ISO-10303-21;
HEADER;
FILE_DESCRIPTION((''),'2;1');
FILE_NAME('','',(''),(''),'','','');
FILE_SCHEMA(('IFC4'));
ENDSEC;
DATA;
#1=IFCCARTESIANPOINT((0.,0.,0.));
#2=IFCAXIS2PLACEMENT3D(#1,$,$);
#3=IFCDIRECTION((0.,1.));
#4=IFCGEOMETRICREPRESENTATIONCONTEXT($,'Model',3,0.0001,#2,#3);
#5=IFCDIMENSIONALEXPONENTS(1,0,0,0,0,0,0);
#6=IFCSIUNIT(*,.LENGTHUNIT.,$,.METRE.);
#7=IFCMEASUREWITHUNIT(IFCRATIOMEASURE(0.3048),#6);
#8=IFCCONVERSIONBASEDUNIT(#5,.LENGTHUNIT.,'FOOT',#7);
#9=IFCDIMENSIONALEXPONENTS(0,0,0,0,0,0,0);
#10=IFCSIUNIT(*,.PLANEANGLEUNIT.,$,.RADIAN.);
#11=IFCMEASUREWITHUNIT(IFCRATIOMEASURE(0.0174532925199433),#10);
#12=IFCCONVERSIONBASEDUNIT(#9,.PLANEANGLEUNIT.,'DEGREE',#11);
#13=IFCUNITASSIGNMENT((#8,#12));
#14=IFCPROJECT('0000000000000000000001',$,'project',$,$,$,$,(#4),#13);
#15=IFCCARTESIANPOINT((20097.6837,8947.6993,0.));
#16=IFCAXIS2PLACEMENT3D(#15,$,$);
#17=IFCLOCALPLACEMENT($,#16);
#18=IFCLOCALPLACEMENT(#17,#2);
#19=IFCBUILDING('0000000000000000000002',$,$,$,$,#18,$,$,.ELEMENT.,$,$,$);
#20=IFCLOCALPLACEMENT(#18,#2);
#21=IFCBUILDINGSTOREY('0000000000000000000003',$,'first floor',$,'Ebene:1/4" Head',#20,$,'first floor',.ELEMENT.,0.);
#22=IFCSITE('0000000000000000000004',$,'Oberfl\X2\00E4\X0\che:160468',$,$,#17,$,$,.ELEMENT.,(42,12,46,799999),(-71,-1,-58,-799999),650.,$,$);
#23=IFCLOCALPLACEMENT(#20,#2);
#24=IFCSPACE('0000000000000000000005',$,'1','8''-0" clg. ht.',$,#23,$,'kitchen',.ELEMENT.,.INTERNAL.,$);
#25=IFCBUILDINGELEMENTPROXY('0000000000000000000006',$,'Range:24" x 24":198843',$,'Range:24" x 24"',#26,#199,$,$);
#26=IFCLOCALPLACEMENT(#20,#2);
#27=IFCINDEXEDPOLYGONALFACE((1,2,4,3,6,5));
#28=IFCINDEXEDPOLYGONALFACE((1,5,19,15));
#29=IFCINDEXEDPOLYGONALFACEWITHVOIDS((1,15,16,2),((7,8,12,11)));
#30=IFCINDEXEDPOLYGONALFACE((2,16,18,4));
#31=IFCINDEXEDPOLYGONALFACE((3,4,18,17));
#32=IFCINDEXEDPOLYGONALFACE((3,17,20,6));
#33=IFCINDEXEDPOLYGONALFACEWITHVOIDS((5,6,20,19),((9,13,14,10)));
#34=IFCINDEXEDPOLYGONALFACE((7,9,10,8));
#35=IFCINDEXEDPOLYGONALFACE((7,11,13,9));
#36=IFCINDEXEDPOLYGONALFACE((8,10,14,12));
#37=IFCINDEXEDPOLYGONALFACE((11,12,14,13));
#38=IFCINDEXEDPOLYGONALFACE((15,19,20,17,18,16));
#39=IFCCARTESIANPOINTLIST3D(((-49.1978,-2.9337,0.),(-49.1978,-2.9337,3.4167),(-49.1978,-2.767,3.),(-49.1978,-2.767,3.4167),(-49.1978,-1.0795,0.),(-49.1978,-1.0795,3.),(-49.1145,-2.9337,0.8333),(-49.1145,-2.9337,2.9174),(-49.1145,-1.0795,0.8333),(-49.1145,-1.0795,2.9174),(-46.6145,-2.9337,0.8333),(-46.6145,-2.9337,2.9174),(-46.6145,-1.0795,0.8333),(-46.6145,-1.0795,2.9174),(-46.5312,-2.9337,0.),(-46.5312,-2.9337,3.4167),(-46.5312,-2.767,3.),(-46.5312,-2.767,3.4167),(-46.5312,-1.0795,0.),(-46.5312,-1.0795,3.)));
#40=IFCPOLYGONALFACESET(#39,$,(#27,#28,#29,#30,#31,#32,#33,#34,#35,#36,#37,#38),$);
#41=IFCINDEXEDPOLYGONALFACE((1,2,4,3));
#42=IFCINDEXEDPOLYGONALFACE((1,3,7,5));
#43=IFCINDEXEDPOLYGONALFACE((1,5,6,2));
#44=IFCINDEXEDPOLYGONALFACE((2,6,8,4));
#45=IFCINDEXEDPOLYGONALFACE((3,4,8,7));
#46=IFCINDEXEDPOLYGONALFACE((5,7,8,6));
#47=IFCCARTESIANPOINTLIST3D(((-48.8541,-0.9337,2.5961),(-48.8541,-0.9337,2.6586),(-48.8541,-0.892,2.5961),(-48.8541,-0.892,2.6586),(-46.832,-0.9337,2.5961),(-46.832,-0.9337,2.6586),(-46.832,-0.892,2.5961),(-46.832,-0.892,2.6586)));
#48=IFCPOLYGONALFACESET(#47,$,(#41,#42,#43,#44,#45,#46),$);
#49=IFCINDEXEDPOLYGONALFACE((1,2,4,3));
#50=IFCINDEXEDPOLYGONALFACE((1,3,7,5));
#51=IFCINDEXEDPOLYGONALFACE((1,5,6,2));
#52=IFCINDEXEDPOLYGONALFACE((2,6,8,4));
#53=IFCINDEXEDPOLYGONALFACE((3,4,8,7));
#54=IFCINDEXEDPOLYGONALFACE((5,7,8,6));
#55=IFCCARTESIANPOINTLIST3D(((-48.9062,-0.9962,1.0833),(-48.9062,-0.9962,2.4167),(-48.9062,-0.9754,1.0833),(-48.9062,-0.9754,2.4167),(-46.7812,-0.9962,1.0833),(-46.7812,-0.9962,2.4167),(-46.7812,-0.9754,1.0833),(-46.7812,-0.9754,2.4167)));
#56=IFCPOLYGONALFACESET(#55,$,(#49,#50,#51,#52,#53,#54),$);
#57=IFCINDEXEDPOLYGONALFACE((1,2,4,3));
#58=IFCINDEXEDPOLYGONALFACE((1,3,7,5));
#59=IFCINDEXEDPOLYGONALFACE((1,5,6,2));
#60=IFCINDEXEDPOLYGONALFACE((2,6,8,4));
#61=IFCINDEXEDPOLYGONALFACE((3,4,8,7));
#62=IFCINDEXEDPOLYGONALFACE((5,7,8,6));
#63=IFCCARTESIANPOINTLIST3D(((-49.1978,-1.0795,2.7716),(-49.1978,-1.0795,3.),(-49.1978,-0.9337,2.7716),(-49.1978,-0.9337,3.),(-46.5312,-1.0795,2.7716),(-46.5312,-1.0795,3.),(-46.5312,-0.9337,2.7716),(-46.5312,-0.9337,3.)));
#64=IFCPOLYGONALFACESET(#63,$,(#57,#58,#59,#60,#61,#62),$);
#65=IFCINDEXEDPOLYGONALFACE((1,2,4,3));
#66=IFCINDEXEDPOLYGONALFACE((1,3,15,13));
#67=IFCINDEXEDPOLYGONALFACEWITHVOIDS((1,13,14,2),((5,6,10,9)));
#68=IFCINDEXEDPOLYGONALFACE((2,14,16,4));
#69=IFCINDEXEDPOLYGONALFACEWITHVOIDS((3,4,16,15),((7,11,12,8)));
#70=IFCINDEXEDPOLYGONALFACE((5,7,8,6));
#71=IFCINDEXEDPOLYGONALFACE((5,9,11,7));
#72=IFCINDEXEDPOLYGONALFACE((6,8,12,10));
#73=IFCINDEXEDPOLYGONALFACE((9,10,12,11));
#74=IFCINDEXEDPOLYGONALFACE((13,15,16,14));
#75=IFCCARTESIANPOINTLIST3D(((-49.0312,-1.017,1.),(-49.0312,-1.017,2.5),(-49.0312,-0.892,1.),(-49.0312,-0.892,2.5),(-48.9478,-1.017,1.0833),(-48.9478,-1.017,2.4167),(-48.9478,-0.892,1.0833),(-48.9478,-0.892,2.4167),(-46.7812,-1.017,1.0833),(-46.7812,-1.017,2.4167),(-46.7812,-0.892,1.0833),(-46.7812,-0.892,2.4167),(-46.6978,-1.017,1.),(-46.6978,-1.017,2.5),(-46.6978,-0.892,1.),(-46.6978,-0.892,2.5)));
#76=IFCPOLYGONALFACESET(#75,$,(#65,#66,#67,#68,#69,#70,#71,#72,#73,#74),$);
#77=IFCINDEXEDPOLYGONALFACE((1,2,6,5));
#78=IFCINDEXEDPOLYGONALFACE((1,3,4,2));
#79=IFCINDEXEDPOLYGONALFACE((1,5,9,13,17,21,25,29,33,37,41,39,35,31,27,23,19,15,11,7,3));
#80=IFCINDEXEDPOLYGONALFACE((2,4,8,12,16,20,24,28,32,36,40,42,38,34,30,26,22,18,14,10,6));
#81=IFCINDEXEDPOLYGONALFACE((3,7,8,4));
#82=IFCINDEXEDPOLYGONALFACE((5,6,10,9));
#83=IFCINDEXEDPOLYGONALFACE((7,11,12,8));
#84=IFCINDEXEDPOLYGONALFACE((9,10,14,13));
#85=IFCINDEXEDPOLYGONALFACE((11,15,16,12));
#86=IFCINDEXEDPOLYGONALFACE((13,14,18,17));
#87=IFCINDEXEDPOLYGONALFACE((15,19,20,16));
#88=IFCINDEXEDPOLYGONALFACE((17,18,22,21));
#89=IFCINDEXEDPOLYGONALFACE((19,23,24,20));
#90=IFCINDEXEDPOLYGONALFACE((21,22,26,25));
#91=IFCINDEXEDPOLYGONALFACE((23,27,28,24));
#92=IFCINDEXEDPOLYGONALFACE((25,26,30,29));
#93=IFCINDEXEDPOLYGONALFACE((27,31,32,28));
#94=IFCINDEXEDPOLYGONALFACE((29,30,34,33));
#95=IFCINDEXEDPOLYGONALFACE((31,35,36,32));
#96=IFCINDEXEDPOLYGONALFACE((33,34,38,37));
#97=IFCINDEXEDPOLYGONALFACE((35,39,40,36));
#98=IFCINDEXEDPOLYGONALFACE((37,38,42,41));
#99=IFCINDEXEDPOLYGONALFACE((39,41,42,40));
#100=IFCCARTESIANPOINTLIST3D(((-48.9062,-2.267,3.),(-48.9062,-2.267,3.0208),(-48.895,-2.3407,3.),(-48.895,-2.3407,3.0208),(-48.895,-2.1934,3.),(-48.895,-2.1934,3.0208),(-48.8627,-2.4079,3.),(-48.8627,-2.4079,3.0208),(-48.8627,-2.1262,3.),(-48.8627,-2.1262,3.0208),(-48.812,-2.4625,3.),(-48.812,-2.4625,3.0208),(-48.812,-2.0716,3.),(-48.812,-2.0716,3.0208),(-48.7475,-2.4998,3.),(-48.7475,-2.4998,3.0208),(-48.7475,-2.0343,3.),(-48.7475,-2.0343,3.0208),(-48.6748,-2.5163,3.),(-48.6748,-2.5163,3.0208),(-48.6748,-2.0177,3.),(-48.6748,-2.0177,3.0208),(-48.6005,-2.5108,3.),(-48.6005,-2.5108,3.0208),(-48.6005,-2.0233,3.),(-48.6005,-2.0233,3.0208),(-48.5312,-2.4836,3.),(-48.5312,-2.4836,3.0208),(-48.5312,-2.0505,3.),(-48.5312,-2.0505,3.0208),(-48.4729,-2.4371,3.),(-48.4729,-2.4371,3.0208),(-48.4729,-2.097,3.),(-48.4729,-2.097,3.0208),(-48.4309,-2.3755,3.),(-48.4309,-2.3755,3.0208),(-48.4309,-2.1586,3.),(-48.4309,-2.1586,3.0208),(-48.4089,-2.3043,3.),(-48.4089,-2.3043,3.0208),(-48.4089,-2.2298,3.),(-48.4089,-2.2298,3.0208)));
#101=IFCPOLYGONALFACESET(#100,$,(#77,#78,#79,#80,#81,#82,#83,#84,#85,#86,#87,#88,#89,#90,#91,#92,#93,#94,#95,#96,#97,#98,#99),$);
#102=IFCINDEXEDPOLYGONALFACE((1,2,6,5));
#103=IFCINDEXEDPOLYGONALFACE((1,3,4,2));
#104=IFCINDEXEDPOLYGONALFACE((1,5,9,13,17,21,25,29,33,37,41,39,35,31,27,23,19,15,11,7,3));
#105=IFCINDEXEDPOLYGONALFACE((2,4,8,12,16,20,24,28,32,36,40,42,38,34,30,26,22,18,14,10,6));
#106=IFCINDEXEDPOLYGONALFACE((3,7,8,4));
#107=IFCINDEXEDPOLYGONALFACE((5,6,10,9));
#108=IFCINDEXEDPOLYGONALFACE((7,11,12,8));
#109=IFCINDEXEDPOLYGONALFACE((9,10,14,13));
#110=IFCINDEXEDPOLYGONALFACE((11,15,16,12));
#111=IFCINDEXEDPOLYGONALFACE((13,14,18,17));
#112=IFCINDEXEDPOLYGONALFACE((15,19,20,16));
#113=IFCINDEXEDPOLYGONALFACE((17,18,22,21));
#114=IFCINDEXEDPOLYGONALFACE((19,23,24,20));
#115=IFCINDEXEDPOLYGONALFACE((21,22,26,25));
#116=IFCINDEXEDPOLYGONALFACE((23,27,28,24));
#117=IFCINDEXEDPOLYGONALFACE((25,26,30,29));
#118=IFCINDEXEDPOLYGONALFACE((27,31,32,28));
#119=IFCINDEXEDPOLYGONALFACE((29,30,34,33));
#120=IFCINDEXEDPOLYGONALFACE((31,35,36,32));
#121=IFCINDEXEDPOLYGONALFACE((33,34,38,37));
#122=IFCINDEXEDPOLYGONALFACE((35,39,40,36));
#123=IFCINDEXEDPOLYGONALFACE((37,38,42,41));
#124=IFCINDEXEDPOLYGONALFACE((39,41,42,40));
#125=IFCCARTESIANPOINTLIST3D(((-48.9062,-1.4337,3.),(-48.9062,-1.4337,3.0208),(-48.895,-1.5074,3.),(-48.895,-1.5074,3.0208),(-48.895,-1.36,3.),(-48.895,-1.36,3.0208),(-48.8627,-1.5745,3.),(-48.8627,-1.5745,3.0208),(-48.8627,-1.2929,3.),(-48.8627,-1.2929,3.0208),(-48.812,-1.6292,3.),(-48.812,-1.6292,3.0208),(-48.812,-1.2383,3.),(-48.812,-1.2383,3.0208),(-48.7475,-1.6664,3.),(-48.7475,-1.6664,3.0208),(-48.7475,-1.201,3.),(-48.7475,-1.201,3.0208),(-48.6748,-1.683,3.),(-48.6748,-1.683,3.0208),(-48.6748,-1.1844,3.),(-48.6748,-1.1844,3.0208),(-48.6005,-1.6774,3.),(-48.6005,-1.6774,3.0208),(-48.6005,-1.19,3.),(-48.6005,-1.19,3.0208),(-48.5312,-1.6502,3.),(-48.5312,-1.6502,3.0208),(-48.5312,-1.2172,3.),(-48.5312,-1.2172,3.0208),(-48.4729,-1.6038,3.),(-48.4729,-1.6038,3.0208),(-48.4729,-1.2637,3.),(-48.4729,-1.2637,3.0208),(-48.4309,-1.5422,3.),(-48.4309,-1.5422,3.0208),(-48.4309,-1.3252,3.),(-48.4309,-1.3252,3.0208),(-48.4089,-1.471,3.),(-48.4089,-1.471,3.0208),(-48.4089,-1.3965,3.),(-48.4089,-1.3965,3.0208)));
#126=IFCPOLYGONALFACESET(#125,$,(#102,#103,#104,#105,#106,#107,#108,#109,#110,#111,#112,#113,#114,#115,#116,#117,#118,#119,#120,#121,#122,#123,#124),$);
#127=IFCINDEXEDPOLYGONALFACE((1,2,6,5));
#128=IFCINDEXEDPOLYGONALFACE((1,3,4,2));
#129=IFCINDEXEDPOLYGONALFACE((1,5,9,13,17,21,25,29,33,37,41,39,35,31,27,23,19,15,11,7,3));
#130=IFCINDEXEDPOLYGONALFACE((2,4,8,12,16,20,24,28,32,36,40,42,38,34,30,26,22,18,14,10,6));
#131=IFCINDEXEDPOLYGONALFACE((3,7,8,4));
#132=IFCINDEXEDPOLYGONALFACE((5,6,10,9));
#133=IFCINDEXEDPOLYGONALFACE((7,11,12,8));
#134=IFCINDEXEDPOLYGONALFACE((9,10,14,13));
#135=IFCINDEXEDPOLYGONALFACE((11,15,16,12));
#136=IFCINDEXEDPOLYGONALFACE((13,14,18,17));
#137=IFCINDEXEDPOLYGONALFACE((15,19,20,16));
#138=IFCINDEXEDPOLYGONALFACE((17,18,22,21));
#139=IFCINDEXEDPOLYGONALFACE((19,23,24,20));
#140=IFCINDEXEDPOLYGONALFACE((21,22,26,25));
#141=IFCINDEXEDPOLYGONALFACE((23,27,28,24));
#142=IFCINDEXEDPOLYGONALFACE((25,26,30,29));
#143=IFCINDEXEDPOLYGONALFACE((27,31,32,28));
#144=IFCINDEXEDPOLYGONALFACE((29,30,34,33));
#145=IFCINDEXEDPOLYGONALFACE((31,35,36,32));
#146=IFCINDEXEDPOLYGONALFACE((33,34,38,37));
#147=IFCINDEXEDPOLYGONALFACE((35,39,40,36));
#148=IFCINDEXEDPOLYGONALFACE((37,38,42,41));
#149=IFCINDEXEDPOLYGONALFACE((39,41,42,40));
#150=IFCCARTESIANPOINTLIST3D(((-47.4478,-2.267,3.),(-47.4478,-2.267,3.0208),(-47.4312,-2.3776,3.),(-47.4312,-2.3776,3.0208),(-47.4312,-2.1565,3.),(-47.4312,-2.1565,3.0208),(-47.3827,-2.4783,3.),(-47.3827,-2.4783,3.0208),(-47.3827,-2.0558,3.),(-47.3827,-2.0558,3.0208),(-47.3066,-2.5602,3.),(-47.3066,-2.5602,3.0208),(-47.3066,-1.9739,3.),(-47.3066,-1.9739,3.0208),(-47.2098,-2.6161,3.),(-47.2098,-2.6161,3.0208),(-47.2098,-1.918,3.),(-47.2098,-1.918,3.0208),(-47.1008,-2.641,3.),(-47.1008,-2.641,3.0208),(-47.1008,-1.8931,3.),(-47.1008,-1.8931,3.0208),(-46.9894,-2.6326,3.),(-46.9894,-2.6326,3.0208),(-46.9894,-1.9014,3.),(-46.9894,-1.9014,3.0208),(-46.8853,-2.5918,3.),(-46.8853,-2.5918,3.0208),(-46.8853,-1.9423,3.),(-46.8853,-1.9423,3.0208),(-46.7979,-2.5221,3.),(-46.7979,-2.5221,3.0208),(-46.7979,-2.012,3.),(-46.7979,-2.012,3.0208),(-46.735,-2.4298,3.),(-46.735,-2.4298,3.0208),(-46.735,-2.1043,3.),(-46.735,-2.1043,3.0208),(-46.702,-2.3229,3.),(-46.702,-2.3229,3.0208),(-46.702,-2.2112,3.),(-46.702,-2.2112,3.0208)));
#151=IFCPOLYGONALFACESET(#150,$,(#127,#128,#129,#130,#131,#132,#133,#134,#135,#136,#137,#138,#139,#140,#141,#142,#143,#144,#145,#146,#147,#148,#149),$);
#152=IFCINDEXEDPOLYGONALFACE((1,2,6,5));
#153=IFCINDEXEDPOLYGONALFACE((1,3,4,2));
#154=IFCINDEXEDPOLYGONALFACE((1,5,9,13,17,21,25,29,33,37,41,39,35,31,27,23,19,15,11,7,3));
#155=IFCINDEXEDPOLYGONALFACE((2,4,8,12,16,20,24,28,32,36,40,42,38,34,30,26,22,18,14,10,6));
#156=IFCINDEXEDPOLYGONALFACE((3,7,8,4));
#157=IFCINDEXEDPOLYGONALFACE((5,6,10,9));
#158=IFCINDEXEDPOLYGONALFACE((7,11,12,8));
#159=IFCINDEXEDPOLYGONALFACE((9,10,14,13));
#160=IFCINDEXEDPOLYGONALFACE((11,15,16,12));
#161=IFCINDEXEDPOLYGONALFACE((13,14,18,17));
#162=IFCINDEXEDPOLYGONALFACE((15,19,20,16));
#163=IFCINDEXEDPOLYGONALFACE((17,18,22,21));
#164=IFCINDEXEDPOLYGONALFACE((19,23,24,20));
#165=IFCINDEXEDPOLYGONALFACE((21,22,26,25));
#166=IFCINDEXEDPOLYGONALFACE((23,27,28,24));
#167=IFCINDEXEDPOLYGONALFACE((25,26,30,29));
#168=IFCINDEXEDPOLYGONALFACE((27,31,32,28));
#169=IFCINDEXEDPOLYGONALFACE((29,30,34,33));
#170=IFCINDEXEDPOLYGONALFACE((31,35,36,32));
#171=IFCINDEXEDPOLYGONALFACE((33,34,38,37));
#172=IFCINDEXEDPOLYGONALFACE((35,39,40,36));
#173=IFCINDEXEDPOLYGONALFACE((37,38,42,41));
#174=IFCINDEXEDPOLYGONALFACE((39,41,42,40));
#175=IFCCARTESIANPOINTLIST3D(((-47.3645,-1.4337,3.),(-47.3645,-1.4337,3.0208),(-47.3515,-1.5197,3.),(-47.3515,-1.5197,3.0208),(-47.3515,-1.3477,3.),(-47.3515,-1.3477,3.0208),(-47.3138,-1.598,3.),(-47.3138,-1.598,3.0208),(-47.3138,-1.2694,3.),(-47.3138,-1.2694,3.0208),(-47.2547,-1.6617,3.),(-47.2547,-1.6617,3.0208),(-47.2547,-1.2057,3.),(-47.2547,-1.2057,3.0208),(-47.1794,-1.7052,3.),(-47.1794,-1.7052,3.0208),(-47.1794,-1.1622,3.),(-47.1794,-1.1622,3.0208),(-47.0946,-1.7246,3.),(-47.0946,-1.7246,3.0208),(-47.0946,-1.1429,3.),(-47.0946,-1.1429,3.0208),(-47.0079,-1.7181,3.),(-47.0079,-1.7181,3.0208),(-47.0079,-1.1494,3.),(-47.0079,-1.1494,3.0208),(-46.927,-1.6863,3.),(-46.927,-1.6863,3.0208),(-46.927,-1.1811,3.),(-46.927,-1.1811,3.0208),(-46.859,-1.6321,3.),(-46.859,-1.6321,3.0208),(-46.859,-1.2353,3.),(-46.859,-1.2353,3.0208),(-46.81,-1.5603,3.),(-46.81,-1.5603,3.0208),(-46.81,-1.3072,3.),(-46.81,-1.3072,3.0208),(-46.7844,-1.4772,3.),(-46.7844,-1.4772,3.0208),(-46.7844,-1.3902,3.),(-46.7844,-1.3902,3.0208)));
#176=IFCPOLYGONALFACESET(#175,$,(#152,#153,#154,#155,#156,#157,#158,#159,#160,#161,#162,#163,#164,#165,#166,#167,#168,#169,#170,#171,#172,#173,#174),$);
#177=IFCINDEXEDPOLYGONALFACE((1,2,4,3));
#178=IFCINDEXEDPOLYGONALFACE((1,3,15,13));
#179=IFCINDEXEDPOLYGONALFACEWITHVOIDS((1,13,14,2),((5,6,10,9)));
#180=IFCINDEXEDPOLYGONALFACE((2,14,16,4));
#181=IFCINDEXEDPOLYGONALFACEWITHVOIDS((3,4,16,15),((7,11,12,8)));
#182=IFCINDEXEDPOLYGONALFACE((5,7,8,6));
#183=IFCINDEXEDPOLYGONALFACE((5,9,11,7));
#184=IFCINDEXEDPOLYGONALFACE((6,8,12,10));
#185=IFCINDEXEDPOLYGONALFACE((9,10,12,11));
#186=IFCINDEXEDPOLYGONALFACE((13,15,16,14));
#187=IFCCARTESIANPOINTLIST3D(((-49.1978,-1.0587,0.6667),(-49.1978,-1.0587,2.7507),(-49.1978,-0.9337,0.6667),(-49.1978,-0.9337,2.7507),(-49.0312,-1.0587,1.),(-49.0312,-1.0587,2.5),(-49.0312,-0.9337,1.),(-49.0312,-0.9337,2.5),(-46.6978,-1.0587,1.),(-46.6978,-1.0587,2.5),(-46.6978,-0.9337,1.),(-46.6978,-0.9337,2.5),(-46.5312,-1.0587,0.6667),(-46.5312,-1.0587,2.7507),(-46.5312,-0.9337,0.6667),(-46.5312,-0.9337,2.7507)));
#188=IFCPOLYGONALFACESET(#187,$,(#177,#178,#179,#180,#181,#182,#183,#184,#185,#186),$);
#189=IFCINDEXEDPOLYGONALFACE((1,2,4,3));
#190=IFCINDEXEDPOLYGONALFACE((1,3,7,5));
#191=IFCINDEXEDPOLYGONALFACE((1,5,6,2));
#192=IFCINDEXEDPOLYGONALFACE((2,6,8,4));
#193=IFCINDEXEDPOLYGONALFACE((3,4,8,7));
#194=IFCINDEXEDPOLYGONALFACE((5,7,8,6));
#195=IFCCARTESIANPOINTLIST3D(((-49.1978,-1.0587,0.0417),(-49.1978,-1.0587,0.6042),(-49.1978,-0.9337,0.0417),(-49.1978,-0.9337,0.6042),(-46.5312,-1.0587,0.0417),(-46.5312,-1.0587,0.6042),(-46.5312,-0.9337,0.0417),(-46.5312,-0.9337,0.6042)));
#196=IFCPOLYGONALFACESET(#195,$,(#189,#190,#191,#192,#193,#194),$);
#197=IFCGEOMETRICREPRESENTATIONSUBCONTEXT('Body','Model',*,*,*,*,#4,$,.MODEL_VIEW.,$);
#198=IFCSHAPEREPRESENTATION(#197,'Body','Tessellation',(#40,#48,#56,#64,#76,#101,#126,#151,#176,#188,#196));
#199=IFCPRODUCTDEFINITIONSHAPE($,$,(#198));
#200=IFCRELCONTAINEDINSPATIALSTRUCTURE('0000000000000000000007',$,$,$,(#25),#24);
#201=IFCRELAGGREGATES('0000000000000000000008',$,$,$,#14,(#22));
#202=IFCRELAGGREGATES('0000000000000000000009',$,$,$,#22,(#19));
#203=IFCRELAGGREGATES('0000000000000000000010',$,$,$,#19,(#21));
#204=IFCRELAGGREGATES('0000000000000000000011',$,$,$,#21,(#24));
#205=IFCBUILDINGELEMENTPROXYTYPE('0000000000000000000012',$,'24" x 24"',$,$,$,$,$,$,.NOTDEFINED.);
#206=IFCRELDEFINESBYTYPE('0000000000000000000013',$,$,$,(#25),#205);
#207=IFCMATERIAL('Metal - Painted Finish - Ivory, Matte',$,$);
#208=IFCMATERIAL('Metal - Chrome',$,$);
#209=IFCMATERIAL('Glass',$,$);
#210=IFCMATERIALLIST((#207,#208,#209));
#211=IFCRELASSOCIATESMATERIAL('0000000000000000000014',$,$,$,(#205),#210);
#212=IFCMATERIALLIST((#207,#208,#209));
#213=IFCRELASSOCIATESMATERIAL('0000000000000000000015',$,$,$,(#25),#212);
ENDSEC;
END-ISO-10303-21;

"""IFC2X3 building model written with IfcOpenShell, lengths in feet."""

from ifc_helpers import new_model, entity, si_unit, converted_unit, direction, frame, frame_2d, origin, origin_2d_with_axis, place, context, subcontext, project, spatial, polyline, rectangle, circle, outline, extrude, source, transform, mapped, material, material_list, type_object, type_shapes, element, save


model = new_model("IFC2X3")

# Units and contexts
model_context = context("Model", 3, precision=0.0001, world=origin(), true_north=direction((0.0, 1.0)))
body_context = subcontext(model_context, "Body", "Model", "MODEL_VIEW")
ifc_project = project(units=[converted_unit("LENGTHUNIT", "FOOT", entity("IfcRatioMeasure", 0.3048), si_unit("LENGTHUNIT", "METRE"), dimensions=[1, 0, 0, 0, 0, 0, 0]), converted_unit("PLANEANGLEUNIT", "DEGREE", entity("IfcRatioMeasure", 0.0174532925199433), si_unit("PLANEANGLEUNIT", "RADIAN"), dimensions=[0, 0, 0, 0, 0, 0, 0])], contexts=[model_context])

# Site, building, storey
site_placement = place(None, frame((20097.6837, 8947.6993, 0.0)))
site = spatial("IfcSite", under=ifc_project, at=site_placement, Name="Oberfläche:160468", CompositionType="ELEMENT", RefLatitude=(42, 12, 46, 799999), RefLongitude=(-71, -1, -58, -799999), RefElevation=650.0)
building_placement = place(site_placement, origin())
building = spatial("IfcBuilding", under=site, at=building_placement, CompositionType="ELEMENT")
storey_placement = place(building_placement, origin())
storey = spatial("IfcBuildingStorey", under=building, at=storey_placement, Name="first floor", ObjectType="Ebene:1/4\" Head", LongName="first floor", CompositionType="ELEMENT", Elevation=0.0)

# Shared definitions
ifc_material_1 = material(Name="Glass")

# Shared definitions
ifc_material_2 = material(Name="Metal - Chrome")

# Shared definitions
space_placement = place(storey_placement, origin())
space = spatial("IfcSpace", under=storey, at=space_placement, Name="1", Description="8'-0\" clg. ht.", LongName="kitchen", CompositionType="ELEMENT", InteriorOrExteriorSpace="INTERNAL")

# Building element proxy, opening
ifc_material_3 = material(Name="Metal - Painted Finish - Ivory, Matte")
ifc_material_list_1 = material_list([ifc_material_3, ifc_material_2, ifc_material_1])
ifc_material_list_2 = material_list([ifc_material_3, ifc_material_2, ifc_material_1])
building_element_proxy_type_1 = type_object("IfcBuildingElementProxyType", Name="24\" x 24\"", PredefinedType="NOTDEFINED", material=ifc_material_list_2)
shared_shape_1 = source(origin(), body_context, "Body", "SweptSolid", [
    extrude(outline(polyline([(-0.6736, -1.2778), (-0.5069, -1.2778), (-0.5069, -0.8611), (1.1806, -0.8611), (1.1806, 2.1389), (-0.6736, 2.1389), (-0.6736, -1.2778)])), frame((0.0, 1.3264, 2.1389), z_axis=(1.0, 0.0, 0.0), x_axis=(0.0, -1.0, 0.0)), (0.0, 0.0, 1.0), 2.6667),
    extrude(rectangle(XDim=0.0417, YDim=2.0221, at=origin_2d_with_axis()), frame((1.3119, -0.0208, 2.5961), z_axis=(0.0, 0.0, 1.0), x_axis=(0.0, 1.0, 0.0)), (0.0, 0.0, 1.0), 0.0625),
    extrude(rectangle(XDim=0.0208, YDim=2.125, at=frame_2d((0.0, 0.0), x_axis=(1.0, 0.0))), frame((1.3125, 0.0521, 1.0833), z_axis=(0.0, 0.0, 1.0), x_axis=(0.0, 1.0, 0.0)), (0.0, 0.0, 1.0), 1.3333),
    extrude(rectangle(XDim=0.1458, YDim=2.6667, at=origin_2d_with_axis()), frame((1.3333, 0.0729, 2.7716), z_axis=(0.0, 0.0, 1.0), x_axis=(0.0, 1.0, 0.0)), (0.0, 0.0, 1.0), 0.2284),
    extrude(outline(polyline([(-0.75, -1.1667), (0.75, -1.1667), (0.75, 1.1667), (-0.75, 1.1667), (-0.75, -1.1667)]), holes=[polyline([(-0.6667, -1.0833), (-0.6667, 1.0833), (0.6667, 1.0833), (0.6667, -1.0833), (-0.6667, -1.0833)])]), frame((1.3333, -0.0417, 1.75), z_axis=(0.0, 1.0, 0.0), x_axis=(0.0, 0.0, -1.0)), (0.0, 0.0, 1.0), 0.125),
    extrude(circle(Radius=0.25, at=frame_2d((0.0, 0.0), x_axis=(1.0, 0.0))), frame((2.125, 1.3333, 3.0)), (0.0, 0.0, 1.0), 0.0208),
    extrude(circle(Radius=0.25, at=frame_2d((0.0, 0.0), x_axis=(1.0, 0.0))), frame((2.125, 0.5, 3.0)), (0.0, 0.0, 1.0), 0.0208),
    extrude(circle(Radius=0.375, at=frame_2d((0.0, 0.0), x_axis=(1.0, 0.0))), frame((0.5417, 1.3333, 3.0)), (0.0, 0.0, 1.0), 0.0208),
    extrude(circle(Radius=0.2917, at=frame_2d((0.0, 0.0), x_axis=(1.0, 0.0))), frame((0.5417, 0.5, 3.0)), (0.0, 0.0, 1.0), 0.0208),
    extrude(rectangle(XDim=0.0833, YDim=2.5, at=frame_2d((0.0, 0.0), x_axis=(1.0, 0.0))), frame((1.3333, 1.9583, 0.8333), z_axis=(0.0, 0.0, 1.0), x_axis=(0.0, -1.0, 0.0)), (0.0, 0.0, 1.0), 2.0841),
    extrude(outline(polyline([(-1.042, -1.3333), (1.042, -1.3333), (1.042, 1.3333), (-1.042, 1.3333), (-1.042, -1.3333)]), holes=[polyline([(-0.7913, -1.1667), (-0.7913, 1.1667), (0.7087, 1.1667), (0.7087, -1.1667), (-0.7913, -1.1667)])]), frame((1.3333, 0.0, 1.7087), z_axis=(0.0, 1.0, 0.0), x_axis=(0.0, 0.0, -1.0)), (0.0, 0.0, 1.0), 0.125),
    extrude(rectangle(XDim=0.125, YDim=2.6667, at=origin_2d_with_axis()), frame((1.3333, 0.0625, 0.0417), z_axis=(0.0, 0.0, 1.0), x_axis=(0.0, 1.0, 0.0)), (0.0, 0.0, 1.0), 0.5625),
])
type_shapes(building_element_proxy_type_1, [shared_shape_1])
proxy_1_placement = place(space_placement, frame((-46.5312, -0.9337, 0.0), z_axis=(0.0, 0.0, 1.0), x_axis=(-1.0, 0.0, 0.0)))
proxy_1 = element("IfcBuildingElementProxy", 1, at=proxy_1_placement, inside=space, type_object=building_element_proxy_type_1, material=ifc_material_list_1, Name="Range:24\" x 24\":198843", ObjectType="Range:24\" x 24\"", context=body_context, shape_type="MappedRepresentation", body=[
    mapped(shared_shape_1, transform((0.0, 0.0, 0.0), scale=1.0)),
])
opening_1_placement = place(storey_placement, frame((-46.5312, -0.9337, 0.0)))
element("IfcOpeningElement", 2, at=opening_1_placement, cuts=proxy_1, ObjectType="Opening", context=body_context, shape_type="SweptSolid", body=[
    extrude(rectangle(XDim=2.0841, YDim=2.5, at=frame_2d((0.0, 0.0), x_axis=(1.0, 0.0))), frame((-1.3333, -0.1458, 1.8754), z_axis=(0.0, -1.0, 0.0), x_axis=(0.0, 0.0, -1.0)), (0.0, 0.0, 1.0), 1.8542),
])

save(model, "model.ifc")
